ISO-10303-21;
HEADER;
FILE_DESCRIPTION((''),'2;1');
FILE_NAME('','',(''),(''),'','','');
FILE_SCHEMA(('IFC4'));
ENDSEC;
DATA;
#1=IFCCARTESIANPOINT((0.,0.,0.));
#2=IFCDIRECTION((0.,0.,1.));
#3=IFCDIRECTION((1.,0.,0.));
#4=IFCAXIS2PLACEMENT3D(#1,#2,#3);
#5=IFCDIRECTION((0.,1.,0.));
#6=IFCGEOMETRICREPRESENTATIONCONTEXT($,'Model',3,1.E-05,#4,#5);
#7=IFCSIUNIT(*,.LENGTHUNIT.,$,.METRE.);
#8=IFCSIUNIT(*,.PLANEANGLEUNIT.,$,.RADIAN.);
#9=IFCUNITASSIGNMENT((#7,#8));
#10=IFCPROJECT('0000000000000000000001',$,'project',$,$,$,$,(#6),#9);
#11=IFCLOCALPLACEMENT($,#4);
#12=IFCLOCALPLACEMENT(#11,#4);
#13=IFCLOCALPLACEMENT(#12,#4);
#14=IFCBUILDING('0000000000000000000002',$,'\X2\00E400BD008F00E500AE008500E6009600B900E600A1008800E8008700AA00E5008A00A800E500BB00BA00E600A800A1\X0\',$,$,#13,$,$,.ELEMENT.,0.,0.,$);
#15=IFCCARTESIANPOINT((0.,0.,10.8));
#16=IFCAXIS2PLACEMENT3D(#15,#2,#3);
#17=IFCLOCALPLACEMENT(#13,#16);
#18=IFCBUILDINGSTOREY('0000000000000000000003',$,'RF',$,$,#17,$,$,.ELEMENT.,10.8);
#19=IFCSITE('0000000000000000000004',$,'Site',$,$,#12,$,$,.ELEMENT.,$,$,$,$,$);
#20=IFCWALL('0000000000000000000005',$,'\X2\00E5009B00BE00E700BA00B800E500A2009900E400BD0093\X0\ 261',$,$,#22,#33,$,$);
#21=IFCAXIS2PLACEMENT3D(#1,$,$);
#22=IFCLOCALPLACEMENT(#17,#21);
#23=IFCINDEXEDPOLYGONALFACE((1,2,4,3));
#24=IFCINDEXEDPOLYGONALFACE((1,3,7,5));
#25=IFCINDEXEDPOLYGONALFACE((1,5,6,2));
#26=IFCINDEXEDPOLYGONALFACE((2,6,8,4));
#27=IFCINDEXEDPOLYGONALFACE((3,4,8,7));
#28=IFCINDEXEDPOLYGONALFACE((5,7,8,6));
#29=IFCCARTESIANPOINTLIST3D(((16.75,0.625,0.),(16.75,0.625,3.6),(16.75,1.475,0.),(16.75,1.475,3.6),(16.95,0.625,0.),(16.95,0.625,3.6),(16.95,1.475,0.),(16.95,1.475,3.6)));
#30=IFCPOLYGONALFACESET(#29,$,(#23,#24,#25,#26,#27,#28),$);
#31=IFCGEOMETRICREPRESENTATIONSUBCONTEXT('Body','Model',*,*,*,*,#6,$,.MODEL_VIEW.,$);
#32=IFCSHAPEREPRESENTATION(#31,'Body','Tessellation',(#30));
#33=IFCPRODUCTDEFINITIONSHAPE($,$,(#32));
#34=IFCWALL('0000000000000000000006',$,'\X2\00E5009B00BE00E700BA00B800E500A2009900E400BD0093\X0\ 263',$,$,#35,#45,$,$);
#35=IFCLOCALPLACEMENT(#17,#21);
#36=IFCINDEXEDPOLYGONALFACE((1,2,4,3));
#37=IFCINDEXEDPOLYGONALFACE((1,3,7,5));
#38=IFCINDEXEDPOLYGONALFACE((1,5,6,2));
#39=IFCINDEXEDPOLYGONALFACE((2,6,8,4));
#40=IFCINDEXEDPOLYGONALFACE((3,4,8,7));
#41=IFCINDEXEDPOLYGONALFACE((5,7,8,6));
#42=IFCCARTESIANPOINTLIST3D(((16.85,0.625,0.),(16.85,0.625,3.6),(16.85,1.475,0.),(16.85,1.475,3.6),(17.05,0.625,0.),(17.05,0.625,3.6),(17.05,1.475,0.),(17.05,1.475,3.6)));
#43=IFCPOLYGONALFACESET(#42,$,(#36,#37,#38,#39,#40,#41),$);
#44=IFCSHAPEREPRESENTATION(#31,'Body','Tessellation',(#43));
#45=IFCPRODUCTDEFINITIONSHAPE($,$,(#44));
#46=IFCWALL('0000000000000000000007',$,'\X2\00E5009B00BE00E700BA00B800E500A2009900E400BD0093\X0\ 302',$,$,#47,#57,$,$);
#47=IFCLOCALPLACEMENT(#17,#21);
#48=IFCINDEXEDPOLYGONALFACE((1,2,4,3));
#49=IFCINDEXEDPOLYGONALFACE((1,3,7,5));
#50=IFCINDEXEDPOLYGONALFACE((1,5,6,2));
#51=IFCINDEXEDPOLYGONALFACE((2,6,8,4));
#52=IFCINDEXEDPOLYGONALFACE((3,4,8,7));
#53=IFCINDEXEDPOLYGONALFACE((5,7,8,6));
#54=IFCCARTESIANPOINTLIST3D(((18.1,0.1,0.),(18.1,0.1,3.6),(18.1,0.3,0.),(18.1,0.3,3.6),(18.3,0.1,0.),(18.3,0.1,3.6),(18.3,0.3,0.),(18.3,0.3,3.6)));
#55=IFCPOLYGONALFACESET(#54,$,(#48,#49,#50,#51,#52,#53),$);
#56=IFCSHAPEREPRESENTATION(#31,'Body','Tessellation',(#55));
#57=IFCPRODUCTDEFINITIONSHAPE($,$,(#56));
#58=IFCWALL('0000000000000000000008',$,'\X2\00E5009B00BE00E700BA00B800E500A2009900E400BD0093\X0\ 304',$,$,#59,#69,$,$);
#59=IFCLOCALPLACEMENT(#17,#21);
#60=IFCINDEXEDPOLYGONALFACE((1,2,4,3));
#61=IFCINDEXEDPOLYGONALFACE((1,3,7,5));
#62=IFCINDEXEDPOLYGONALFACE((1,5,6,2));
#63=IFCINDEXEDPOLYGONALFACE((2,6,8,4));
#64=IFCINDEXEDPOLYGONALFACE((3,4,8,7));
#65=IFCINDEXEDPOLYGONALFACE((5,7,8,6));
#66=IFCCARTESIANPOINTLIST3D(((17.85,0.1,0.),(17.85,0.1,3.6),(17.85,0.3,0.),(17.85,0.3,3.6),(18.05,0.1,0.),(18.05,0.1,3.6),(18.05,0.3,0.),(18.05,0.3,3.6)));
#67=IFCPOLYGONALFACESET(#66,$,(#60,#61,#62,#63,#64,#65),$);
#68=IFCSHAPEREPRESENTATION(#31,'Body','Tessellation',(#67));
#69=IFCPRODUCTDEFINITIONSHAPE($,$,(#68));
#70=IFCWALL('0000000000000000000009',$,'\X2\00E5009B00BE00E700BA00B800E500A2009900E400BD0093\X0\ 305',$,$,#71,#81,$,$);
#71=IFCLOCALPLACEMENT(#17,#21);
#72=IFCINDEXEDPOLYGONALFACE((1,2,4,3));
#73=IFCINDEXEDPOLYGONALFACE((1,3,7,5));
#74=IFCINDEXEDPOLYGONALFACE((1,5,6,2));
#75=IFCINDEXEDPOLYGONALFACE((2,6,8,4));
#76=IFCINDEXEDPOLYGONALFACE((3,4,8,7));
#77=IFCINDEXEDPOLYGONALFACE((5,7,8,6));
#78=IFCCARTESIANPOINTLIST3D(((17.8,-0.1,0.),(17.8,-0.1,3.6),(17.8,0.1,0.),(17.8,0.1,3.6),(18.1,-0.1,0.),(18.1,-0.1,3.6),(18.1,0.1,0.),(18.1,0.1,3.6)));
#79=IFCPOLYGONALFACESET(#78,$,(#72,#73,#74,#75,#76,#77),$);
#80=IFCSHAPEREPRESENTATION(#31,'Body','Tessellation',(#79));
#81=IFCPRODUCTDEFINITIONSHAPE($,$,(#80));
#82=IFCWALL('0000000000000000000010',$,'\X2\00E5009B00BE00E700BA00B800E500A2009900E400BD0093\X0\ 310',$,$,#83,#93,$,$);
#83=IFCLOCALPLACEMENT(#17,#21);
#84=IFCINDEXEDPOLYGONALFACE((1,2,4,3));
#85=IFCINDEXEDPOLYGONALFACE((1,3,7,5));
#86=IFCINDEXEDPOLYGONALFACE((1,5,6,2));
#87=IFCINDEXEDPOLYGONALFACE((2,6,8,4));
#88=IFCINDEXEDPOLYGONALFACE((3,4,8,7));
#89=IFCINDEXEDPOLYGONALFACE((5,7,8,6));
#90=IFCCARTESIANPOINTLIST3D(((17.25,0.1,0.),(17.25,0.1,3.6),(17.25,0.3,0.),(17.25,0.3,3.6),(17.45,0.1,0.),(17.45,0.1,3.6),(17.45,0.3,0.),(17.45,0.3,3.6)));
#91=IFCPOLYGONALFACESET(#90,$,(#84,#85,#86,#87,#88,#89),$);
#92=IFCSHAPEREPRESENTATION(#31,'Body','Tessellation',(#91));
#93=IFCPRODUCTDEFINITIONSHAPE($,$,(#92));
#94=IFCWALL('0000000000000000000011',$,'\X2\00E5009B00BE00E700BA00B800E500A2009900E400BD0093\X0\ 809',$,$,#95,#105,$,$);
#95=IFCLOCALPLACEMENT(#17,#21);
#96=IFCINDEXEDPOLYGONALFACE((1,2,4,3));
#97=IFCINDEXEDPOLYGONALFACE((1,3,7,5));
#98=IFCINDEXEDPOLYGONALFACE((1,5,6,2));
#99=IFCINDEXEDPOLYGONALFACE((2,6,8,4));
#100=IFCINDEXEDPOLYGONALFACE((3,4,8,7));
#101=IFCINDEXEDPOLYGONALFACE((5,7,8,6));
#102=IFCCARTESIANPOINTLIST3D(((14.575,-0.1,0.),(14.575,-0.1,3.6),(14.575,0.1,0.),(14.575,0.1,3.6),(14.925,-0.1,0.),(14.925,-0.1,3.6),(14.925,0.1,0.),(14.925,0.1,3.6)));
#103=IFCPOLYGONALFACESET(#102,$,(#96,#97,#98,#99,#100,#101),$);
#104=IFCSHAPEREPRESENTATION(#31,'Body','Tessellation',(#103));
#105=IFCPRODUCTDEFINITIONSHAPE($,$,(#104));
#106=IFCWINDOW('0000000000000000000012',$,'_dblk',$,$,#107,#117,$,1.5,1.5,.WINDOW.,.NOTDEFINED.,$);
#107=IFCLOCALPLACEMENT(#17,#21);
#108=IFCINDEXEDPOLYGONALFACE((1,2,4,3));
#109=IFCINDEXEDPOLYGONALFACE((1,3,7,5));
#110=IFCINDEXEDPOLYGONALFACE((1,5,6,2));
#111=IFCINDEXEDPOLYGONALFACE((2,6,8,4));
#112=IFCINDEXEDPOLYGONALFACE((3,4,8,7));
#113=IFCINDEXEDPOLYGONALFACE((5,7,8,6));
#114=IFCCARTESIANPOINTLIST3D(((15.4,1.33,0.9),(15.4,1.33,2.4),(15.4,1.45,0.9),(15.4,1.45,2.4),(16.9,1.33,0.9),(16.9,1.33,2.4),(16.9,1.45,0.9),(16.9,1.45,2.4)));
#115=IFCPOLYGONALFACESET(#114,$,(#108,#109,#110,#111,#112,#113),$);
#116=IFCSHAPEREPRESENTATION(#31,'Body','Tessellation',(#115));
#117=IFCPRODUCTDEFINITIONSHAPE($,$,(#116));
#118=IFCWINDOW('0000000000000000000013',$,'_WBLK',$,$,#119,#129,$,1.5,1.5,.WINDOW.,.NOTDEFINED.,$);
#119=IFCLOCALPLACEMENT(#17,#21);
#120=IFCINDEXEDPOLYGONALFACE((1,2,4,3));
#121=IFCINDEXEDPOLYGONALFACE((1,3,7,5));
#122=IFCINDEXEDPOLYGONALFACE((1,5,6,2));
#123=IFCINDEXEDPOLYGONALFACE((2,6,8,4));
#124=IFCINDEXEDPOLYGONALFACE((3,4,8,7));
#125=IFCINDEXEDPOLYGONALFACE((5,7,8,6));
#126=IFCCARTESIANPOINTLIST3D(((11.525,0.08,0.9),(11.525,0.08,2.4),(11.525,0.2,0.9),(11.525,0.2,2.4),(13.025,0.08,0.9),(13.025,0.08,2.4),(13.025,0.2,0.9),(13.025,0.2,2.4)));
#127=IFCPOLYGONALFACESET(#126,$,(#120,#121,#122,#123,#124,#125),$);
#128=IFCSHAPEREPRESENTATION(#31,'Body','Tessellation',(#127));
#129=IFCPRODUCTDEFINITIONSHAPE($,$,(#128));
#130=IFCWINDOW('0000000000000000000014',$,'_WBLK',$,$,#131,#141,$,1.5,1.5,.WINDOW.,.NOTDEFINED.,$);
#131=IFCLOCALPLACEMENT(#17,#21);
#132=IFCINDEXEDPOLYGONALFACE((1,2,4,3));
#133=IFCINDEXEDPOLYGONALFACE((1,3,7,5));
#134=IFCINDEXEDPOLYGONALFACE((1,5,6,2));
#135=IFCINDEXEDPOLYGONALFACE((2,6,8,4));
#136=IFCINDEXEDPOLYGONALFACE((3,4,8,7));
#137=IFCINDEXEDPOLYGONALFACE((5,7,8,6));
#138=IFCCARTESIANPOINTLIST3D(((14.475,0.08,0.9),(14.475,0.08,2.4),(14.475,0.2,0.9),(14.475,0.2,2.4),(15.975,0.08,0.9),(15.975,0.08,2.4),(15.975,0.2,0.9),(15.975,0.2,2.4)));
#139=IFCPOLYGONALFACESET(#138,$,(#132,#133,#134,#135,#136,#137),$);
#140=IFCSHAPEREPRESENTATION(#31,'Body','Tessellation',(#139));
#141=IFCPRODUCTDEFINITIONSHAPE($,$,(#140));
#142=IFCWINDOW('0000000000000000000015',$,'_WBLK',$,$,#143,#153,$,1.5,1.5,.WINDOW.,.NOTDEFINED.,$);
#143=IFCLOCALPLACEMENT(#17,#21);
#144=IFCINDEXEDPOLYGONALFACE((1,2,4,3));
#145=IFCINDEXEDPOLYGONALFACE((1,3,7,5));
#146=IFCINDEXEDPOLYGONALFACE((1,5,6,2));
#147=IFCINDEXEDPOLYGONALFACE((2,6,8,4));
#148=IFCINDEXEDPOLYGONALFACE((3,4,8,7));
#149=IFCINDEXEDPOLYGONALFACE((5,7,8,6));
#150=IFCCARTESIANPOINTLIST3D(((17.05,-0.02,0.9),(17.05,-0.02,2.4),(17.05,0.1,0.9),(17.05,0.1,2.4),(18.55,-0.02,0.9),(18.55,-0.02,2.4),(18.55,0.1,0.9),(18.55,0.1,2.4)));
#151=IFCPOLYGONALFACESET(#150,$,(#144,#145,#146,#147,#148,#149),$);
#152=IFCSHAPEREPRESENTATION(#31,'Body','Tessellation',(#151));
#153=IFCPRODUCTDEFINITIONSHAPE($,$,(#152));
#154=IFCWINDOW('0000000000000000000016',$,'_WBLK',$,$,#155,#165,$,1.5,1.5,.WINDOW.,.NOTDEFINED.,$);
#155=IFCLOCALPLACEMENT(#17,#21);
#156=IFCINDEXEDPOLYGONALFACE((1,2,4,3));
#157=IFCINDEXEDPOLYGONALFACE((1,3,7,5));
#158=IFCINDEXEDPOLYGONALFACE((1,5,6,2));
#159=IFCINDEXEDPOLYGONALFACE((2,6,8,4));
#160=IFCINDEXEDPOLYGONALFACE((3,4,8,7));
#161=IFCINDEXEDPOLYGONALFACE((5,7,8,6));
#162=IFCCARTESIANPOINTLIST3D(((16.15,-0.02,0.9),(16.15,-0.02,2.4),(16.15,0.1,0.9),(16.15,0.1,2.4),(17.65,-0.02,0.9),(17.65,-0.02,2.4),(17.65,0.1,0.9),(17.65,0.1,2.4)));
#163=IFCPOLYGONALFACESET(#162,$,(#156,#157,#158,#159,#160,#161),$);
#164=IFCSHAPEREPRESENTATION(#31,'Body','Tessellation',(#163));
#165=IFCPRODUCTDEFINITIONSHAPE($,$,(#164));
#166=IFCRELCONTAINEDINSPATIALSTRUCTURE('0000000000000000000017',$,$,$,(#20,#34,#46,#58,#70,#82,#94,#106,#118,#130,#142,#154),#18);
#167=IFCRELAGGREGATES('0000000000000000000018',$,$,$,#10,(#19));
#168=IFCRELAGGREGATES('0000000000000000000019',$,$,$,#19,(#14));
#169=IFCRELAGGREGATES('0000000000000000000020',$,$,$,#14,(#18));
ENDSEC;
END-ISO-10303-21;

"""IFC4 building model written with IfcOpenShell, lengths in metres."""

from ifc_helpers import new_model, si_unit, direction, frame, frame_2d, origin_with_axes, place, context, subcontext, project, spatial, rectangle, extrude, element, save


model = new_model("IFC4")

# Units and contexts
model_context = context("Model", 3, precision=1e-05, world=origin_with_axes(), true_north=direction((0.0, 1.0, 0.0)))
body_context = subcontext(model_context, "Body", "Model", "MODEL_VIEW")
ifc_project = project(units=[si_unit("LENGTHUNIT", "METRE"), si_unit("PLANEANGLEUNIT", "RADIAN")], contexts=[model_context])

# Site, building, storey
placement = place(None, origin_with_axes())
site_placement = place(placement, origin_with_axes())
site = spatial("IfcSite", under=ifc_project, at=site_placement, Name="Site", CompositionType="ELEMENT")
building_placement = place(site_placement, origin_with_axes())
building = spatial("IfcBuilding", under=site, at=building_placement, Name="ä½\u008få®\u0085æ\u0096¹æ¡\u0088è\u0087ªå\u008a¨å»ºæ¨¡", CompositionType="ELEMENT", ElevationOfRefHeight=0.0, ElevationOfTerrain=0.0)
storey_placement = place(building_placement, frame((0.0, 0.0, 10.8), z_axis=(0.0, 0.0, 1.0), x_axis=(1.0, 0.0, 0.0)))
storey = spatial("IfcBuildingStorey", under=building, at=storey_placement, Name="RF", CompositionType="ELEMENT", Elevation=10.8)

# Walls
for number, where, z_axis, x_axis, name in (
    (1, (16.85, 1.05, 0.0), (0.0, 0.0, 1.0), (0.0, -1.0, 0.0), "å\u009b¾çº¸å¢\u0099ä½\u0093 261"),
    (2, (16.95, 1.05, 0.0), (0.0, 0.0, 1.0), (0.0, -1.0, 0.0), "å\u009b¾çº¸å¢\u0099ä½\u0093 263"),
):
    element("IfcWall", number, at=place(storey_placement, frame(where, z_axis=z_axis, x_axis=x_axis)), inside=storey, Name=name, context=body_context, shape_type="SweptSolid", body=[
        extrude(rectangle(XDim=0.85, YDim=0.2, at=frame_2d((0.0, 0.0), x_axis=(1.0, 0.0, 0.0))), frame((0.0, 0.0, 0.0), z_axis=(0.0, 0.0, 1.0)), (0.0, 0.0, 1.0), 3.6),
    ])
for number, where, z_axis, x_axis, name in (
    (3, (18.2, 0.2, 0.0), (0.0, 0.0, 1.0), (1.0, 0.0, 0.0), "å\u009b¾çº¸å¢\u0099ä½\u0093 302"),
    (4, (17.95, 0.2, 0.0), (0.0, 0.0, 1.0), (1.0, 0.0, 0.0), "å\u009b¾çº¸å¢\u0099ä½\u0093 304"),
):
    element("IfcWall", number, at=place(storey_placement, frame(where, z_axis=z_axis, x_axis=x_axis)), inside=storey, Name=name, context=body_context, shape_type="SweptSolid", body=[
        extrude(rectangle(XDim=0.2, YDim=0.2, at=frame_2d((0.0, 0.0), x_axis=(1.0, 0.0, 0.0))), frame((0.0, 0.0, 0.0), z_axis=(0.0, 0.0, 1.0)), (0.0, 0.0, 1.0), 3.6),
    ])
wall_1_placement = place(storey_placement, frame((17.95, 0.0, 0.0), z_axis=(0.0, 0.0, 1.0), x_axis=(1.0, 0.0, 0.0)))
element("IfcWall", 5, at=wall_1_placement, inside=storey, Name="å\u009b¾çº¸å¢\u0099ä½\u0093 305", context=body_context, shape_type="SweptSolid", body=[
    extrude(rectangle(XDim=0.3, YDim=0.2, at=frame_2d((0.0, 0.0), x_axis=(1.0, 0.0, 0.0))), frame((0.0, 0.0, 0.0), z_axis=(0.0, 0.0, 1.0)), (0.0, 0.0, 1.0), 3.6),
])
for number, where, z_axis, x_axis, name in (
    (6, (17.35, 0.2, 0.0), (0.0, 0.0, 1.0), (0.0, -1.0, 0.0), "å\u009b¾çº¸å¢\u0099ä½\u0093 310"),
):
    element("IfcWall", number, at=place(storey_placement, frame(where, z_axis=z_axis, x_axis=x_axis)), inside=storey, Name=name, context=body_context, shape_type="SweptSolid", body=[
        extrude(rectangle(XDim=0.2, YDim=0.2, at=frame_2d((0.0, 0.0), x_axis=(1.0, 0.0, 0.0))), frame((0.0, 0.0, 0.0), z_axis=(0.0, 0.0, 1.0)), (0.0, 0.0, 1.0), 3.6),
    ])
wall_2_placement = place(storey_placement, frame((14.75, 0.0, 0.0), z_axis=(0.0, 0.0, 1.0), x_axis=(1.0, 0.0, 0.0)))
element("IfcWall", 7, at=wall_2_placement, inside=storey, Name="å\u009b¾çº¸å¢\u0099ä½\u0093 809", context=body_context, shape_type="SweptSolid", body=[
    extrude(rectangle(XDim=0.35, YDim=0.2, at=frame_2d((0.0, 0.0), x_axis=(1.0, 0.0, 0.0))), frame((0.0, 0.0, 0.0), z_axis=(0.0, 0.0, 1.0)), (0.0, 0.0, 1.0), 3.6),
])

# Windows
for number, where, z_axis, x_axis, name in (
    (8, (16.15, 1.39, 0.9), (0.0, 0.0, 1.0), (1.0, 0.0, 0.0), "_dblk"),
    (9, (12.275, 0.14, 0.9), (0.0, 0.0, 1.0), (1.0, 0.0, 0.0), "_WBLK"),
    (10, (15.225, 0.14, 0.9), (0.0, 0.0, 1.0), (1.0, 0.0, 0.0), "_WBLK"),
    (11, (17.8, 0.04, 0.9), (0.0, 0.0, 1.0), (1.0, 0.0, 0.0), "_WBLK"),
    (12, (16.9, 0.04, 0.9), (0.0, 0.0, 1.0), (1.0, 0.0, 0.0), "_WBLK"),
):
    element("IfcWindow", number, at=place(storey_placement, frame(where, z_axis=z_axis, x_axis=x_axis)), inside=storey, Name=name, OverallHeight=1.5, OverallWidth=1.5, PartitioningType="NOTDEFINED", PredefinedType="WINDOW", context=body_context, shape_type="SweptSolid", body=[
        extrude(rectangle(XDim=1.5, YDim=0.12, at=frame_2d((0.0, 0.0), x_axis=(1.0, 0.0, 0.0))), frame((0.0, 0.0, 0.0), z_axis=(0.0, 0.0, 1.0)), (0.0, 0.0, 1.0), 1.5),
    ])

save(model, "model.ifc")
